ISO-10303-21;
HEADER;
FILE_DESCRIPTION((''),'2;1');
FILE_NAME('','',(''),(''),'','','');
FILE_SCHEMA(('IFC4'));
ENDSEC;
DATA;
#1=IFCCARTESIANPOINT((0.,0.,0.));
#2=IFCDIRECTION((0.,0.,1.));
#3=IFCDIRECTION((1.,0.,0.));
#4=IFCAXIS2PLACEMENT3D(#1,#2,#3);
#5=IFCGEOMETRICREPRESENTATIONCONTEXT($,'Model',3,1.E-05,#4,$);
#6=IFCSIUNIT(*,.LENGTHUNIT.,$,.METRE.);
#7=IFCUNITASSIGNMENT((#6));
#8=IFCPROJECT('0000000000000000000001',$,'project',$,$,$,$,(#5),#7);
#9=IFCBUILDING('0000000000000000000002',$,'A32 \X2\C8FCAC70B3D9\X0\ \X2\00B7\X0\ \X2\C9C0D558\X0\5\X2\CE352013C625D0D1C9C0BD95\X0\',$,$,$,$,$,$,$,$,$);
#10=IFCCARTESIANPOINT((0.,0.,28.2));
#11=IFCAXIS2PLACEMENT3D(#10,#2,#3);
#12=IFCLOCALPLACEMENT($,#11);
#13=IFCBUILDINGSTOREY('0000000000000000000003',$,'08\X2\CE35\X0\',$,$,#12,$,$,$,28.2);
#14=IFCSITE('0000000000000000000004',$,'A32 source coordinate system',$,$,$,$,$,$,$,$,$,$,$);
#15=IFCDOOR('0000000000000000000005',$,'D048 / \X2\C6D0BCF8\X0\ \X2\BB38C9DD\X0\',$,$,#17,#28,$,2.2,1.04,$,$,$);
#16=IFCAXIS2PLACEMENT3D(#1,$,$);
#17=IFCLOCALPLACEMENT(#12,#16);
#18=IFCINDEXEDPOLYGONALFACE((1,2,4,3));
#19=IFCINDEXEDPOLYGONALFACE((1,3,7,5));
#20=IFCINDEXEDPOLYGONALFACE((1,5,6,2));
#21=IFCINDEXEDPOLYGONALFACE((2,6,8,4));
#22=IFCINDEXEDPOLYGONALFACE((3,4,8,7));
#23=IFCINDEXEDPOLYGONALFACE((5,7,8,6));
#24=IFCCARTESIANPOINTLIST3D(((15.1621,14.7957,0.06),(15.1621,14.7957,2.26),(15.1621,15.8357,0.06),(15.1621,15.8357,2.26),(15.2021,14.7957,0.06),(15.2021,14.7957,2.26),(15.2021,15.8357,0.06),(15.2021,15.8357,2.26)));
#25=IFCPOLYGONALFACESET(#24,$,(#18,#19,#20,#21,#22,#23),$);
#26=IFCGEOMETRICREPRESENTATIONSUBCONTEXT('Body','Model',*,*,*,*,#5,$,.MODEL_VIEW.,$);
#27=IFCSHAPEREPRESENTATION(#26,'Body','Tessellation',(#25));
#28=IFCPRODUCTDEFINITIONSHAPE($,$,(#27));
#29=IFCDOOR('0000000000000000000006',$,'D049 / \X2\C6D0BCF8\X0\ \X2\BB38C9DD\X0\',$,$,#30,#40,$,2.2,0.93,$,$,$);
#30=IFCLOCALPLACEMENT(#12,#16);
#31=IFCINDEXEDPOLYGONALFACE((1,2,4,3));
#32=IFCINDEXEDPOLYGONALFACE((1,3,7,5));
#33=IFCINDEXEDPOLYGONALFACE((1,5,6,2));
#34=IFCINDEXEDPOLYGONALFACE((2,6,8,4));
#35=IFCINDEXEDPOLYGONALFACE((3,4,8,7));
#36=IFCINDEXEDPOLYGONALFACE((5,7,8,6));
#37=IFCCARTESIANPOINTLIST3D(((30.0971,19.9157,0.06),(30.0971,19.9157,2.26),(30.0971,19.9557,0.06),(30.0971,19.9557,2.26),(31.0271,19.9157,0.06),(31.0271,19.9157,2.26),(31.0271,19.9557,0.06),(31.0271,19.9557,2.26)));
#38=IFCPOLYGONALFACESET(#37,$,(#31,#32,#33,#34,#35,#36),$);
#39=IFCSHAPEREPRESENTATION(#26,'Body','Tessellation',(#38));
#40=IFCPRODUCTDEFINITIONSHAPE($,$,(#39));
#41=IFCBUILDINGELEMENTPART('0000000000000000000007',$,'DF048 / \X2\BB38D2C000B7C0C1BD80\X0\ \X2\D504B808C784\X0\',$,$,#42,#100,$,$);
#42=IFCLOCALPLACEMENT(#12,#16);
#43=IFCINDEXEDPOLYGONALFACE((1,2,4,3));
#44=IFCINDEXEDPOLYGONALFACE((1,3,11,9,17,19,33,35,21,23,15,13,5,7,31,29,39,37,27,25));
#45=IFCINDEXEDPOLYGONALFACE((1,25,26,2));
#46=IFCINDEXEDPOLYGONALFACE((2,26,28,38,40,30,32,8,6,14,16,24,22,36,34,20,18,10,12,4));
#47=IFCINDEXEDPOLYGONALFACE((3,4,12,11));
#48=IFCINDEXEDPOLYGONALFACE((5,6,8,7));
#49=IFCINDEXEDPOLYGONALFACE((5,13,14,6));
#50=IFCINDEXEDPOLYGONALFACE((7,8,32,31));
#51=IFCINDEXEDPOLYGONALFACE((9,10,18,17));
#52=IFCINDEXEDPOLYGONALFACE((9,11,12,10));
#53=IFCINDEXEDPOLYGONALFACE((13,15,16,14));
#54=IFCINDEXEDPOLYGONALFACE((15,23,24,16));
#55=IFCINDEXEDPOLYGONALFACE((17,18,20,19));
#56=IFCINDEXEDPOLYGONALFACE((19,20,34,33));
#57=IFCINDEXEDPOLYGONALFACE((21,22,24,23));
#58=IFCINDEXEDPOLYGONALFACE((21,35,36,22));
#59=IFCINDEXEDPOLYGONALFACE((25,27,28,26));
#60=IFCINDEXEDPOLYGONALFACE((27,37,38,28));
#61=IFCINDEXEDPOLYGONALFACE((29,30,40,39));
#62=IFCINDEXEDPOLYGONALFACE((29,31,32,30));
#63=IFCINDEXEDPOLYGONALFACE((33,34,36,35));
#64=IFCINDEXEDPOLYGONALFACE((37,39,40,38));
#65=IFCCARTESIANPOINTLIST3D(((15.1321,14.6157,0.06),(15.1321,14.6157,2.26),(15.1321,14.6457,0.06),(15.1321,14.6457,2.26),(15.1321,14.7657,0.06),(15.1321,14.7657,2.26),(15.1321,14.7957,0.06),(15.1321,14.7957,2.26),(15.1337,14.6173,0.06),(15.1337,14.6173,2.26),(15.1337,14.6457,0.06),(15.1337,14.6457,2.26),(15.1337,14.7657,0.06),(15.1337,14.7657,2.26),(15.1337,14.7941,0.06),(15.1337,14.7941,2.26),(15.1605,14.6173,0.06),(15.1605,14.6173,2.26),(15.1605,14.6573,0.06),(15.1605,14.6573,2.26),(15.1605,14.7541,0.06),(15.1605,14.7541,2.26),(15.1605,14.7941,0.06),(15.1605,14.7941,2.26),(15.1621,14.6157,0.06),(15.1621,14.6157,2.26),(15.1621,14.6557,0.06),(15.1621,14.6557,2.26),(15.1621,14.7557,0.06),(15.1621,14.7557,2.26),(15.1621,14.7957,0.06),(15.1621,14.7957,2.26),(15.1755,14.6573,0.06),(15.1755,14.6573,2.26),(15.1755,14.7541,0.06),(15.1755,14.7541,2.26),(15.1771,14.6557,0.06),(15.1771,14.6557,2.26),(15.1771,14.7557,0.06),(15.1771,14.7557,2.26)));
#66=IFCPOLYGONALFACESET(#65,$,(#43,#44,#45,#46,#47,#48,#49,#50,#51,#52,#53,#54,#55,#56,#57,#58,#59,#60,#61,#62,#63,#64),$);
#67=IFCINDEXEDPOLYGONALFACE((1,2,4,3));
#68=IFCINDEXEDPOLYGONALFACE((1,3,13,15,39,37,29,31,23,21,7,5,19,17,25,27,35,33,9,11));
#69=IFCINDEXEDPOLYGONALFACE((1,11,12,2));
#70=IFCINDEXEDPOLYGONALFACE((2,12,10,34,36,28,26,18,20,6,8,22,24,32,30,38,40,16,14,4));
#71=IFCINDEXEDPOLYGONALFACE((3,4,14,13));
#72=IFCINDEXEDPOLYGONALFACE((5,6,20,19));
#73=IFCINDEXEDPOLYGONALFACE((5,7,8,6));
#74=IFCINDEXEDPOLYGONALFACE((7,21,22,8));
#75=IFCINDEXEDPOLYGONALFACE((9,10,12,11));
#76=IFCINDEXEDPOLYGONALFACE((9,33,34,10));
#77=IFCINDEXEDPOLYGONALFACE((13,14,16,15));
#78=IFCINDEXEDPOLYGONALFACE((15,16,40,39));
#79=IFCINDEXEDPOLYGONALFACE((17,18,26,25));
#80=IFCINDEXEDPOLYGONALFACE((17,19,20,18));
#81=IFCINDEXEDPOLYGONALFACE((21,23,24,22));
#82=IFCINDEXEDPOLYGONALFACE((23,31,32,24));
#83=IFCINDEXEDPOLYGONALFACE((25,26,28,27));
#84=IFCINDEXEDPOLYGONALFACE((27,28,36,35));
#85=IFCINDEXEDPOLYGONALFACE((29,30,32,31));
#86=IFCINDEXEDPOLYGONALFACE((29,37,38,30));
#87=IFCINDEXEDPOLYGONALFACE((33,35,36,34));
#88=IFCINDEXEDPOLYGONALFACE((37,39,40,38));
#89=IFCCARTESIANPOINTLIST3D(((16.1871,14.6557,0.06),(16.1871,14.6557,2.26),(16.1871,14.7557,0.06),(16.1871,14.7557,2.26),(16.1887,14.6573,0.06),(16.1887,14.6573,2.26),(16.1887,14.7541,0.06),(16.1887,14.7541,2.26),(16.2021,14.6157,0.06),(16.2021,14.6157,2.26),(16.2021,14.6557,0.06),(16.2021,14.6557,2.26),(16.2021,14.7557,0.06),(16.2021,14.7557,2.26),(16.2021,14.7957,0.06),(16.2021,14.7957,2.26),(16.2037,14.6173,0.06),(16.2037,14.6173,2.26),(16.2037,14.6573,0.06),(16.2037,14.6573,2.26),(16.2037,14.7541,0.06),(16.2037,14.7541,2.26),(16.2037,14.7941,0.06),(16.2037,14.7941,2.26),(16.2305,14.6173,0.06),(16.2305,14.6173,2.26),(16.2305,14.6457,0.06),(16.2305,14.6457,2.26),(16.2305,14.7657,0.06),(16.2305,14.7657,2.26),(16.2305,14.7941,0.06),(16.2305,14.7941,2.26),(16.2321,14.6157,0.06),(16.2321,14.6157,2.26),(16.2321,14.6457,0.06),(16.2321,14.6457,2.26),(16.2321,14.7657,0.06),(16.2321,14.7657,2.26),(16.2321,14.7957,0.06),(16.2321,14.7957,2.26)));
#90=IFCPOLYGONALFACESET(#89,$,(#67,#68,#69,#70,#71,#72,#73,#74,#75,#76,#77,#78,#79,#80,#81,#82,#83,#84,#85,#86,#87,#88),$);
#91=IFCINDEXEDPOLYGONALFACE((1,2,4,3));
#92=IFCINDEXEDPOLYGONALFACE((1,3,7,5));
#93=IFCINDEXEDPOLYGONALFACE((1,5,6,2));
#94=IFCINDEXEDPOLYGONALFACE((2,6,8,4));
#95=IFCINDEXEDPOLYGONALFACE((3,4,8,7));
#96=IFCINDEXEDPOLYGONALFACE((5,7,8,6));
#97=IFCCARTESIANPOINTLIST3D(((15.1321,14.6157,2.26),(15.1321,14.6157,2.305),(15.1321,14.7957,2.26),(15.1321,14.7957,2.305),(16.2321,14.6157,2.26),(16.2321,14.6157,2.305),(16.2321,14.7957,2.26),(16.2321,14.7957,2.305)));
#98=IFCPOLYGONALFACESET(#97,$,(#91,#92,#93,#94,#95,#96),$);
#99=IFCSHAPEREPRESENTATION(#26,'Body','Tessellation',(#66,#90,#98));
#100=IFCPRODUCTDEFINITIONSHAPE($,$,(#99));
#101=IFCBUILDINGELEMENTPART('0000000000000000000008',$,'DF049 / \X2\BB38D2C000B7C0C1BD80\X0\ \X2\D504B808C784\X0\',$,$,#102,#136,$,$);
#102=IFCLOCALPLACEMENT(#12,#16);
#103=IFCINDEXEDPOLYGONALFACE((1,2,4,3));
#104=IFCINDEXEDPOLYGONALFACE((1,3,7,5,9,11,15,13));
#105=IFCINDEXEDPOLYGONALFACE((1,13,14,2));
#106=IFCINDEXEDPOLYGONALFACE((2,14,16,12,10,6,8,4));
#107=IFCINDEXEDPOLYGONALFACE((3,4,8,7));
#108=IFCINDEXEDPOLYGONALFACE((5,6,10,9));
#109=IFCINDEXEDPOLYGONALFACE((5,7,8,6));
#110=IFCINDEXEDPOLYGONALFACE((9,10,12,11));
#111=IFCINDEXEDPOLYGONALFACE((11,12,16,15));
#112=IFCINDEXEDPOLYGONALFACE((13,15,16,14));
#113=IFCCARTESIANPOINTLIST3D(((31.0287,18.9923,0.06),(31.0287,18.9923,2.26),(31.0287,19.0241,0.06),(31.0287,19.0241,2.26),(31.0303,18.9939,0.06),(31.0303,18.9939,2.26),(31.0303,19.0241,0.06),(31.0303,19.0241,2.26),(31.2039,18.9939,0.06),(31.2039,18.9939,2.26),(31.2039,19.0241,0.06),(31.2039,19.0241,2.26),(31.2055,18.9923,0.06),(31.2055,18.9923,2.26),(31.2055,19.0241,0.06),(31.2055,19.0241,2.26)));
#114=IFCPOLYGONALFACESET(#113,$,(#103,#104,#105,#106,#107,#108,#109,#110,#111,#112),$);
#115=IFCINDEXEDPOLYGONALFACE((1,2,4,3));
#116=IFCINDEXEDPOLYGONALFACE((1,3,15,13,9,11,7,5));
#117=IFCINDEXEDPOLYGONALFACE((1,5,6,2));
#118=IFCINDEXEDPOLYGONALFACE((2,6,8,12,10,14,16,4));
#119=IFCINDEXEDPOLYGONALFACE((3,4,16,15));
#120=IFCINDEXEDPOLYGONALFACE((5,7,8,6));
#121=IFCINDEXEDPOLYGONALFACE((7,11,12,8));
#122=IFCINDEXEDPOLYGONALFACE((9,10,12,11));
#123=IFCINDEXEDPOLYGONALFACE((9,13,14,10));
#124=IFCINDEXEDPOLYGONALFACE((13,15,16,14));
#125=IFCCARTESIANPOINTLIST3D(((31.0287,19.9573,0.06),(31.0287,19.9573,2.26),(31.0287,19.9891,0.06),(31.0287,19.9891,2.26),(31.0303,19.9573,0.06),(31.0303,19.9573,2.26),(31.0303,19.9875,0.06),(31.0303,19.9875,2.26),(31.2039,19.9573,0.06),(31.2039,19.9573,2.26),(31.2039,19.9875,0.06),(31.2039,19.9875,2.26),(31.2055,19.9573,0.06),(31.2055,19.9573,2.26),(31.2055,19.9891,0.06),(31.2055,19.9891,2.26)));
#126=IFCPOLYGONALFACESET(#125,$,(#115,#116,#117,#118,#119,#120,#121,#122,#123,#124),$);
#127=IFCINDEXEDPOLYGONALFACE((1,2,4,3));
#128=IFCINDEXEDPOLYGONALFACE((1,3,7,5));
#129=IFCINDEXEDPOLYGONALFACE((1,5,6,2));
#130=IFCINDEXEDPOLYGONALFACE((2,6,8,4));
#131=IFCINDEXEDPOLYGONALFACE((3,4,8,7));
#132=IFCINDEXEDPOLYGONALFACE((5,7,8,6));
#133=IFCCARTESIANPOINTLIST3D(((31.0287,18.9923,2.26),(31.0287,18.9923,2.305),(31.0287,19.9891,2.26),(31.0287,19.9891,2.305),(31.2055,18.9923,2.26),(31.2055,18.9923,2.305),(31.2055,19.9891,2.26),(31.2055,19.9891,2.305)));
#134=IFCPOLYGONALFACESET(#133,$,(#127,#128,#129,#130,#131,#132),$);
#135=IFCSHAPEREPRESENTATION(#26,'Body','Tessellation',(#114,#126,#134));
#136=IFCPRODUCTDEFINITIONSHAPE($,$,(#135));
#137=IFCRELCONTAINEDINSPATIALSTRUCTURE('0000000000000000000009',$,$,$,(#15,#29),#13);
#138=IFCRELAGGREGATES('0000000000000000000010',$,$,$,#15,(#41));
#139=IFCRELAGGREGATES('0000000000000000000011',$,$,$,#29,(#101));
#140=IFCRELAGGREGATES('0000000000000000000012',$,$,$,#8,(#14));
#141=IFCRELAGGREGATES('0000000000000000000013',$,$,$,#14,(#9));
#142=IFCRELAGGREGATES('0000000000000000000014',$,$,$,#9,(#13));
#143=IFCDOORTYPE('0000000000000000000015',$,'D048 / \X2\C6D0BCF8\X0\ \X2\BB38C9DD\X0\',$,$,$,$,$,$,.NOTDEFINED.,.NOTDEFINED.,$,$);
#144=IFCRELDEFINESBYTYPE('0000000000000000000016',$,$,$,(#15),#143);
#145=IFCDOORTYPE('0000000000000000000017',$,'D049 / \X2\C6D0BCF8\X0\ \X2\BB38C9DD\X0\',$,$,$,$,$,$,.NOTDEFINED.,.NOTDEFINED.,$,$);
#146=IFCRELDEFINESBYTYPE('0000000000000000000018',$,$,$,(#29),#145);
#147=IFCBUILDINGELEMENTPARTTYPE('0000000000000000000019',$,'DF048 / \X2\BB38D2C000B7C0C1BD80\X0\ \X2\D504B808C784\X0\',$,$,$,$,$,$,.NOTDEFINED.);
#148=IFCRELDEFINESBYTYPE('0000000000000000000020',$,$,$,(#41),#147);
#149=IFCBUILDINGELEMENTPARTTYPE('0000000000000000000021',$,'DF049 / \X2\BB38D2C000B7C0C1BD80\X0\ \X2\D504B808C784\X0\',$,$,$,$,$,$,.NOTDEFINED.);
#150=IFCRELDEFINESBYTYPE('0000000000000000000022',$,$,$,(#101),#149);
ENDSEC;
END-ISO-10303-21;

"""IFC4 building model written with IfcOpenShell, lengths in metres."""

from ifc_helpers import new_model, si_unit, frame, origin, origin_with_axes, place, context, subcontext, project, spatial, polyline, outline, extrude, source, transform, mapped, type_object, type_shapes, element, aggregate, save


model = new_model("IFC4")

# Units and contexts
model_context = context("Model", 3, precision=1e-05, world=origin_with_axes())
body_context = subcontext(model_context, "Body", "Model", "MODEL_VIEW")
ifc_project = project(units=[si_unit("LENGTHUNIT", "METRE")], contexts=[model_context])

# Site, building, storey
storey_placement = place(None, frame((0.0, 0.0, 28.2), z_axis=(0.0, 0.0, 1.0), x_axis=(1.0, 0.0, 0.0)))
site = spatial("IfcSite", under=ifc_project, Name="A32 source coordinate system")
building = spatial("IfcBuilding", under=site, Name="A32 주거동 · 지하5층–옥탑지붕")
storey = spatial("IfcBuildingStorey", under=building, at=storey_placement, Name="08층", Elevation=28.2)

# Doors
door_type_1 = type_object("IfcDoorType", Name="D048 / 원본 문짝", OperationType="NOTDEFINED", PredefinedType="NOTDEFINED")
shared_shape_1 = source(origin(), body_context, "Body", "SweptSolid", [
    extrude(outline(polyline([(15.2021, 15.8357), (15.2021, 14.7957), (15.1621, 14.7957), (15.1621, 15.8357), (15.2021, 15.8357)])), frame((0.0, 0.0, 0.06)), (0.0, 0.0, 1.0), 2.2),
])
type_shapes(door_type_1, [shared_shape_1])
door_1_placement = place(storey_placement, origin_with_axes())
door_1 = element("IfcDoor", 1, at=door_1_placement, inside=storey, type_object=door_type_1, Name="D048 / 원본 문짝", OverallHeight=2.2, OverallWidth=1.04, context=body_context, shape_type="MappedRepresentation", body=[
    mapped(shared_shape_1, transform((0.0, 0.0, 0.0), scale=1.0)),
])
door_type_2 = type_object("IfcDoorType", Name="D049 / 원본 문짝", OperationType="NOTDEFINED", PredefinedType="NOTDEFINED")
shared_shape_2 = source(origin(), body_context, "Body", "SweptSolid", [
    extrude(outline(polyline([(31.0271, 19.9557), (31.0271, 19.9157), (30.0971, 19.9157), (30.0971, 19.9557), (31.0271, 19.9557)])), frame((0.0, 0.0, 0.06)), (0.0, 0.0, 1.0), 2.2),
])
type_shapes(door_type_2, [shared_shape_2])
door_2_placement = place(storey_placement, origin_with_axes())
door_2 = element("IfcDoor", 2, at=door_2_placement, inside=storey, type_object=door_type_2, Name="D049 / 원본 문짝", OverallHeight=2.2, OverallWidth=0.93, context=body_context, shape_type="MappedRepresentation", body=[
    mapped(shared_shape_2, transform((0.0, 0.0, 0.0), scale=1.0)),
])

# Building element parts
building_element_part_type_1 = type_object("IfcBuildingElementPartType", Name="DF048 / 문틀·상부 프레임", PredefinedType="NOTDEFINED")
shared_shape_3 = source(origin(), body_context, "Body", "SweptSolid", [
    extrude(outline(polyline([(15.1321, 14.7657), (15.1321, 14.7957), (15.1621, 14.7957), (15.1621, 14.7557), (15.1771, 14.7557), (15.1771, 14.6557), (15.1621, 14.6557), (15.1621, 14.6157), (15.1321, 14.6157), (15.1321, 14.6457), (15.1337, 14.6457), (15.1337, 14.6173), (15.1605, 14.6173), (15.1605, 14.6573), (15.1755, 14.6573), (15.1755, 14.7541), (15.1605, 14.7541), (15.1605, 14.7941), (15.1337, 14.7941), (15.1337, 14.7657), (15.1321, 14.7657)])), frame((0.0, 0.0, 0.06)), (0.0, 0.0, 1.0), 2.2),
    extrude(outline(polyline([(16.2305, 14.7941), (16.2037, 14.7941), (16.2037, 14.7541), (16.1887, 14.7541), (16.1887, 14.6573), (16.2037, 14.6573), (16.2037, 14.6173), (16.2305, 14.6173), (16.2305, 14.6457), (16.2321, 14.6457), (16.2321, 14.6157), (16.2021, 14.6157), (16.2021, 14.6557), (16.1871, 14.6557), (16.1871, 14.7557), (16.2021, 14.7557), (16.2021, 14.7957), (16.2321, 14.7957), (16.2321, 14.7657), (16.2305, 14.7657), (16.2305, 14.7941)])), frame((0.0, 0.0, 0.06)), (0.0, 0.0, 1.0), 2.2),
    extrude(outline(polyline([(15.1321, 14.6157), (15.1321, 14.7957), (16.2321, 14.7957), (16.2321, 14.6157), (15.1321, 14.6157)])), frame((0.0, 0.0, 2.26)), (0.0, 0.0, 1.0), 0.045),
])
type_shapes(building_element_part_type_1, [shared_shape_3])
building_element_part_1_placement = place(door_1_placement, origin_with_axes())
building_element_part_1 = element("IfcBuildingElementPart", 3, at=building_element_part_1_placement, type_object=building_element_part_type_1, Name="DF048 / 문틀·상부 프레임", context=body_context, shape_type="MappedRepresentation", body=[
    mapped(shared_shape_3, transform((0.0, 0.0, 0.0), scale=1.0)),
])
aggregate(door_1, [building_element_part_1])
building_element_part_type_2 = type_object("IfcBuildingElementPartType", Name="DF049 / 문틀·상부 프레임", PredefinedType="NOTDEFINED")
shared_shape_4 = source(origin(), body_context, "Body", "SweptSolid", [
    extrude(outline(polyline([(31.0303, 19.0241), (31.0303, 18.9939), (31.2039, 18.9939), (31.2039, 19.0241), (31.2055, 19.0241), (31.2055, 18.9923), (31.0287, 18.9923), (31.0287, 19.0241), (31.0303, 19.0241)])), frame((0.0, 0.0, 0.06)), (0.0, 0.0, 1.0), 2.2),
    extrude(outline(polyline([(31.0287, 19.9891), (31.2055, 19.9891), (31.2055, 19.9573), (31.2039, 19.9573), (31.2039, 19.9875), (31.0303, 19.9875), (31.0303, 19.9573), (31.0287, 19.9573), (31.0287, 19.9891)])), frame((0.0, 0.0, 0.06)), (0.0, 0.0, 1.0), 2.2),
    extrude(outline(polyline([(31.0287, 18.9923), (31.0287, 19.9891), (31.2055, 19.9891), (31.2055, 18.9923), (31.0287, 18.9923)])), frame((0.0, 0.0, 2.26)), (0.0, 0.0, 1.0), 0.045),
])
type_shapes(building_element_part_type_2, [shared_shape_4])
building_element_part_2_placement = place(door_2_placement, origin_with_axes())
building_element_part_2 = element("IfcBuildingElementPart", 4, at=building_element_part_2_placement, type_object=building_element_part_type_2, Name="DF049 / 문틀·상부 프레임", context=body_context, shape_type="MappedRepresentation", body=[
    mapped(shared_shape_4, transform((0.0, 0.0, 0.0), scale=1.0)),
])
aggregate(door_2, [building_element_part_2])

save(model, "model.ifc")
